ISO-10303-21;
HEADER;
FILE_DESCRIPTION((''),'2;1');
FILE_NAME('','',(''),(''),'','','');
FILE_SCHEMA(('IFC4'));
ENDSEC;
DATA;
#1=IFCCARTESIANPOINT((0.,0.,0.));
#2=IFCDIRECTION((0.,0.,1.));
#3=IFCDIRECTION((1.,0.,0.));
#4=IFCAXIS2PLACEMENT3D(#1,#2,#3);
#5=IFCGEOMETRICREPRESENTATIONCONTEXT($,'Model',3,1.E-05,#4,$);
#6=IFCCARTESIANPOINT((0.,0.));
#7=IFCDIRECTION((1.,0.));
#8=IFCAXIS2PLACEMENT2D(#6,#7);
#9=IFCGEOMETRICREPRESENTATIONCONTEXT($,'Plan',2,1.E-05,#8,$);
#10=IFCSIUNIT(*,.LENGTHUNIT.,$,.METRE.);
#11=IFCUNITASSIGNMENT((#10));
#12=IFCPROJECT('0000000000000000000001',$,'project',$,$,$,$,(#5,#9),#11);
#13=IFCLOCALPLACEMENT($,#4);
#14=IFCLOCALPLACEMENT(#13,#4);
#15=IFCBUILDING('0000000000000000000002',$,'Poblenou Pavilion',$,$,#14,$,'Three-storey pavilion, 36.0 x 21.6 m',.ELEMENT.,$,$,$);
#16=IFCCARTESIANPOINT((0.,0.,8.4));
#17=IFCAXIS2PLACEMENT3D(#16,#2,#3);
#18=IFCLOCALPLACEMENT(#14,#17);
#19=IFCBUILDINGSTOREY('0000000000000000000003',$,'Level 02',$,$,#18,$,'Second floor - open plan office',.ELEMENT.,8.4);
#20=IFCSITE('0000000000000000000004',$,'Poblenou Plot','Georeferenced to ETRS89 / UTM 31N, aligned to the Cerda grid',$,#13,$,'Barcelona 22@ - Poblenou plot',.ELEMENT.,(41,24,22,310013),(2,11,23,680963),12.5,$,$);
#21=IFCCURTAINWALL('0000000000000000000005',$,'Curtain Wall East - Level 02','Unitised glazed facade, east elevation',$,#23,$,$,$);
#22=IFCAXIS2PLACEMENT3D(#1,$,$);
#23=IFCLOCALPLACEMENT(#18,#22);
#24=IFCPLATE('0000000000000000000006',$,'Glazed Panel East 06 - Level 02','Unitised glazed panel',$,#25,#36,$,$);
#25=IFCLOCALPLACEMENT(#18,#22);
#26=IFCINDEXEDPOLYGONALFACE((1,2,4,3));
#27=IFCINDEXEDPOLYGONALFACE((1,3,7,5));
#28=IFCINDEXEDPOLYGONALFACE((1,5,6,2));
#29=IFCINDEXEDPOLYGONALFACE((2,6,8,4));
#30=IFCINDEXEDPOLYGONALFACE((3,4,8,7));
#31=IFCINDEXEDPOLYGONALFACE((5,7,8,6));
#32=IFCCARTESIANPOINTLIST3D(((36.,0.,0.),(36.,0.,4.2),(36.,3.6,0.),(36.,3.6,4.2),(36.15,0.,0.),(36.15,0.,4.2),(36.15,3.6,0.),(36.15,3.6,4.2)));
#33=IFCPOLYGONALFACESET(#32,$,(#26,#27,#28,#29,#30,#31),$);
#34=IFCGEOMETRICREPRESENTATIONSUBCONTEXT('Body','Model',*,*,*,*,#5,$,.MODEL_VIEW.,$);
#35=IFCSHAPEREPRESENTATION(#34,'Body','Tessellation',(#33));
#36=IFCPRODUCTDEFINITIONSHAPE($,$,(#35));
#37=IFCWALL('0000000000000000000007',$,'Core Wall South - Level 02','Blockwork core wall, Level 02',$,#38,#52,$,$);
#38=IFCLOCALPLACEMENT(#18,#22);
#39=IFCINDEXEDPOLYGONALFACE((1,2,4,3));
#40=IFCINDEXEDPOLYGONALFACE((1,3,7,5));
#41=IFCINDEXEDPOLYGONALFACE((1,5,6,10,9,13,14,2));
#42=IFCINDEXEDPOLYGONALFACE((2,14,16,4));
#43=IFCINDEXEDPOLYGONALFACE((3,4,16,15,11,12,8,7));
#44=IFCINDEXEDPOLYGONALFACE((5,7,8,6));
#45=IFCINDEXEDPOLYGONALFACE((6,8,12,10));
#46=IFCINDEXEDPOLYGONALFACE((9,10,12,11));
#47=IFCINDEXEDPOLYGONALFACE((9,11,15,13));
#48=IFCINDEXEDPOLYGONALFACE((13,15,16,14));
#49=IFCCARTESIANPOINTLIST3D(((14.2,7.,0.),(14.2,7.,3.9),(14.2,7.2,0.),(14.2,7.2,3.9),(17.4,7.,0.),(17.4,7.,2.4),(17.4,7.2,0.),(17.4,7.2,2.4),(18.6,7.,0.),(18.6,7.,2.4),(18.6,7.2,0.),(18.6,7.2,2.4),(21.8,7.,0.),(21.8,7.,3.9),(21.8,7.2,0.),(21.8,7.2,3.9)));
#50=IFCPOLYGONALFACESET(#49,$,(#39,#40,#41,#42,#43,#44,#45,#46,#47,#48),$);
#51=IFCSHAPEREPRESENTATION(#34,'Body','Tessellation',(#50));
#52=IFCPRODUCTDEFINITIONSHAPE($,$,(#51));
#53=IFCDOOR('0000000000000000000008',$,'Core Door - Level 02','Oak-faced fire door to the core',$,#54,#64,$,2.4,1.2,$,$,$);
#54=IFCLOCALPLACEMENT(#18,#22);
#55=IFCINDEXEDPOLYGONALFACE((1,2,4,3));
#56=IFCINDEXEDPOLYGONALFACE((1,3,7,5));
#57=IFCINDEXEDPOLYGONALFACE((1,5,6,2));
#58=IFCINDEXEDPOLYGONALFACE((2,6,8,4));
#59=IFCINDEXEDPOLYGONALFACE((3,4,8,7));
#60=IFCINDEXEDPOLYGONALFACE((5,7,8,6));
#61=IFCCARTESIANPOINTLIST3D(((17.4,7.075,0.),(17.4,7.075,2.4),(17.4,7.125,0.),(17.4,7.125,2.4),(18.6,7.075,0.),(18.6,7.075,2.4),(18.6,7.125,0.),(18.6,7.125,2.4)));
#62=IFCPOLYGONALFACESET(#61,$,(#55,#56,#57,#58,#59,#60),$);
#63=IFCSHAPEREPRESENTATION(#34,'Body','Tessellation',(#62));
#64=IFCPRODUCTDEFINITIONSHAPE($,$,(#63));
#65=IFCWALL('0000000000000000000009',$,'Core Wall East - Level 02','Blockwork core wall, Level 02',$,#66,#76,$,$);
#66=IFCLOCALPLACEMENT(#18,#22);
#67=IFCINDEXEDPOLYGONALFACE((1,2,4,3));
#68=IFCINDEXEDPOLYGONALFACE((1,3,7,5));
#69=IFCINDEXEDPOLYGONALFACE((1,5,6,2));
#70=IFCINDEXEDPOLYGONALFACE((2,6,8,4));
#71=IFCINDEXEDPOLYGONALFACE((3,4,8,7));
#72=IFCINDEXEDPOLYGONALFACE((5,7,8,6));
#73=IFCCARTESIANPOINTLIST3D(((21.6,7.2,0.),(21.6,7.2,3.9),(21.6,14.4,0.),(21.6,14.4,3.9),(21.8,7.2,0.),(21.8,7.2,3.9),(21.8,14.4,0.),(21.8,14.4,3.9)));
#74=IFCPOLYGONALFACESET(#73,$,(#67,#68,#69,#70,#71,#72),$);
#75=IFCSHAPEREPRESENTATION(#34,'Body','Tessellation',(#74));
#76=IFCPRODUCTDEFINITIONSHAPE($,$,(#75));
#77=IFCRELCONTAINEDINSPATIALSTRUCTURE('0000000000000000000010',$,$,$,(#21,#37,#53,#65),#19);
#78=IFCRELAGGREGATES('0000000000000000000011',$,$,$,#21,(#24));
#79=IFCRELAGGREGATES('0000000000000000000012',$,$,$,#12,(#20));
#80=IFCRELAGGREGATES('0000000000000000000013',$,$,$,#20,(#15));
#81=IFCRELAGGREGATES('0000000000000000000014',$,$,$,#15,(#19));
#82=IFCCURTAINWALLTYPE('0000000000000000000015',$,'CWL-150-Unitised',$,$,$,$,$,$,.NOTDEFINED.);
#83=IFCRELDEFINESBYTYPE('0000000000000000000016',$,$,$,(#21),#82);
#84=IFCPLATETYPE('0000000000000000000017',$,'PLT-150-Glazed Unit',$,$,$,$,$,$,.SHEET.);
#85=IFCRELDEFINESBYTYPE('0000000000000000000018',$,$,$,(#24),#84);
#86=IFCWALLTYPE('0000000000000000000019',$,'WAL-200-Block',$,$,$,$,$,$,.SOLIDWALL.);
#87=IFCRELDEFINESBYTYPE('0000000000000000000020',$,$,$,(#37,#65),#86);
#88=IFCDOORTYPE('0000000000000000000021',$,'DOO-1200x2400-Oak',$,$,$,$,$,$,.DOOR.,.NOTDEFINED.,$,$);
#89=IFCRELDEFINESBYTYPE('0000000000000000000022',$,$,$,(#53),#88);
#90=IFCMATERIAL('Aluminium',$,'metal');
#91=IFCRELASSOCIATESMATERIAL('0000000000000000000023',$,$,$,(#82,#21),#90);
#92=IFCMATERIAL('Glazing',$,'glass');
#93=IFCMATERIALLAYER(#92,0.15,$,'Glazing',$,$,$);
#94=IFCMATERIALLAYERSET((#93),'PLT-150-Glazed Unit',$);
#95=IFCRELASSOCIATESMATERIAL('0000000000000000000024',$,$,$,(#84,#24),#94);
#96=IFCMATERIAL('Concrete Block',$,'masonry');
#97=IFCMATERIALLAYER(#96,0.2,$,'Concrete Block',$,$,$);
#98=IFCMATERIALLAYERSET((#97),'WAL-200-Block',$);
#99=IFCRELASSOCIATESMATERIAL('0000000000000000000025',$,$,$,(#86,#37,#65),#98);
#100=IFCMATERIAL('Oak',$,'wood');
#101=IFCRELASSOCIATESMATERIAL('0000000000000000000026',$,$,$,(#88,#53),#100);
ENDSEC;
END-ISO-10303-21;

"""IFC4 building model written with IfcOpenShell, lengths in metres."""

from ifc_helpers import new_model, si_unit, frame, origin_with_axes, origin_2d_with_axis, place, context, subcontext, project, spatial, line, indexed_curve, outline, extrude, material, layer, layer_set, layer_usage, type_object, element, fill, aggregate, save


model = new_model("IFC4")

# Units and contexts
model_context = context("Model", 3, precision=1e-05, world=origin_with_axes())
plan_context = context("Plan", 2, precision=1e-05, world=origin_2d_with_axis())
body_context = subcontext(model_context, "Body", "Model", "MODEL_VIEW")
ifc_project = project(units=[si_unit("LENGTHUNIT", "METRE")], contexts=[model_context, plan_context])

# Site, building, storey
site_placement = place(None, origin_with_axes())
site = spatial("IfcSite", under=ifc_project, at=site_placement, Name="Poblenou Plot", Description="Georeferenced to ETRS89 / UTM 31N, aligned to the Cerda grid", LongName="Barcelona 22@ - Poblenou plot", CompositionType="ELEMENT", RefLatitude=(41, 24, 22, 310013), RefLongitude=(2, 11, 23, 680963), RefElevation=12.5)
building_placement = place(site_placement, origin_with_axes())
building = spatial("IfcBuilding", under=site, at=building_placement, Name="Poblenou Pavilion", LongName="Three-storey pavilion, 36.0 x 21.6 m", CompositionType="ELEMENT")
storey_placement = place(building_placement, frame((0.0, 0.0, 8.4), z_axis=(0.0, 0.0, 1.0), x_axis=(1.0, 0.0, 0.0)))
storey = spatial("IfcBuildingStorey", under=building, at=storey_placement, Name="Level 02", LongName="Second floor - open plan office", CompositionType="ELEMENT", Elevation=8.4)

# Curtain wall, plate
ifc_material_1 = material(Name="Aluminium", Category="metal")
curtain_wall_type = type_object("IfcCurtainWallType", Name="CWL-150-Unitised", PredefinedType="NOTDEFINED", material=ifc_material_1)
ifc_material_2 = material(Name="Glazing", Category="glass")
ifc_layer_1 = layer(ifc_material_2, 0.15, Name="Glazing")
ifc_layer_set_1 = layer_set([ifc_layer_1], Name="PLT-150-Glazed Unit")
plate_type = type_object("IfcPlateType", Name="PLT-150-Glazed Unit", PredefinedType="SHEET", material=ifc_layer_set_1)
curtain_wall_1_placement = place(storey_placement, frame((36.0, 21.6, 0.0), z_axis=(0.0, 0.0, 1.0), x_axis=(0.0, -1.0, 0.0)))
curtain_wall_1 = element("IfcCurtainWall", 1, at=curtain_wall_1_placement, inside=storey, type_object=curtain_wall_type, material=ifc_material_1, Name="Curtain Wall East - Level 02", Description="Unitised glazed facade, east elevation")
ifc_layer_usage_1 = layer_usage(ifc_layer_set_1, "AXIS2", "POSITIVE", 0.0)
plate_1_placement = place(curtain_wall_1_placement, frame((18.0, 0.0, 0.0), z_axis=(0.0, 0.0, 1.0), x_axis=(1.0, 0.0, 0.0)))
plate_1 = element("IfcPlate", 2, at=plate_1_placement, type_object=plate_type, material=ifc_layer_usage_1, Name="Glazed Panel East 06 - Level 02", Description="Unitised glazed panel", context=body_context, shape_type="SweptSolid", body=[
    extrude(outline(indexed_curve([(0.0, 0.0), (3.6, 0.0), (3.6, 0.15), (0.0, 0.15)], segments=[line(1, 2, 3, 4, 1)])), origin_with_axes(), (0.0, 0.0, 1.0), 4.2),
])
aggregate(curtain_wall_1, [plate_1])

# Wall, opening, door
ifc_material_3 = material(Name="Concrete Block", Category="masonry")
ifc_layer_2 = layer(ifc_material_3, 0.2, Name="Concrete Block")
ifc_layer_set_2 = layer_set([ifc_layer_2], Name="WAL-200-Block")
ifc_layer_usage_2 = layer_usage(ifc_layer_set_2, "AXIS2", "POSITIVE", 0.0)
wall_type = type_object("IfcWallType", Name="WAL-200-Block", PredefinedType="SOLIDWALL", material=ifc_layer_set_2)
wall_1_placement = place(storey_placement, frame((21.8, 7.2, 0.0), z_axis=(0.0, 0.0, 1.0), x_axis=(-1.0, 0.0, 0.0)))
wall_1 = element("IfcWall", 3, at=wall_1_placement, inside=storey, type_object=wall_type, material=ifc_layer_usage_2, Name="Core Wall South - Level 02", Description="Blockwork core wall, Level 02", context=body_context, shape_type="SweptSolid", body=[
    extrude(outline(indexed_curve([(0.0, 0.0), (7.6, 0.0), (7.6, 0.2), (0.0, 0.2)], segments=[line(1, 2, 3, 4, 1)])), origin_with_axes(), (0.0, 0.0, 1.0), 3.9),
])
opening_placement = place(wall_1_placement, frame((4.4, 0.21, 0.0), z_axis=(0.0, 0.0, 1.0), x_axis=(-1.0, 0.0, 0.0)))
opening = element("IfcOpeningElement", 4, at=opening_placement, cuts=wall_1, PredefinedType="OPENING", context=body_context, shape_type="SweptSolid", body=[
    extrude(outline(indexed_curve([(0.0, 0.0), (1.2, 0.0), (1.2, 0.22), (0.0, 0.22)], segments=[line(1, 2, 3, 4, 1)])), origin_with_axes(), (0.0, 0.0, 1.0), 2.4),
])
ifc_material_4 = material(Name="Oak", Category="wood")
door_type = type_object("IfcDoorType", Name="DOO-1200x2400-Oak", OperationType="NOTDEFINED", PredefinedType="DOOR", material=ifc_material_4)
door_placement = place(storey_placement, frame((17.4, 7.075, 0.0), z_axis=(0.0, 0.0, 1.0), x_axis=(1.0, 0.0, 0.0)))
door = element("IfcDoor", 5, at=door_placement, inside=storey, type_object=door_type, material=ifc_material_4, Name="Core Door - Level 02", Description="Oak-faced fire door to the core", OverallHeight=2.4, OverallWidth=1.2, context=body_context, shape_type="SweptSolid", body=[
    extrude(outline(indexed_curve([(0.0, 0.0), (1.2, 0.0), (1.2, 0.05), (0.0, 0.05)], segments=[line(1, 2, 3, 4, 1)])), origin_with_axes(), (0.0, 0.0, 1.0), 2.4),
])
fill(opening, door)

# Wall
ifc_layer_usage_3 = layer_usage(ifc_layer_set_2, "AXIS2", "POSITIVE", 0.0)
wall_2_placement = place(storey_placement, frame((21.6, 14.4, 0.0), z_axis=(0.0, 0.0, 1.0), x_axis=(0.0, -1.0, 0.0)))
element("IfcWall", 6, at=wall_2_placement, inside=storey, type_object=wall_type, material=ifc_layer_usage_3, Name="Core Wall East - Level 02", Description="Blockwork core wall, Level 02", context=body_context, shape_type="SweptSolid", body=[
    extrude(outline(indexed_curve([(0.0, 0.0), (7.2, 0.0), (7.2, 0.2), (0.0, 0.2)], segments=[line(1, 2, 3, 4, 1)])), origin_with_axes(), (0.0, 0.0, 1.0), 3.9),
])

save(model, "model.ifc")
